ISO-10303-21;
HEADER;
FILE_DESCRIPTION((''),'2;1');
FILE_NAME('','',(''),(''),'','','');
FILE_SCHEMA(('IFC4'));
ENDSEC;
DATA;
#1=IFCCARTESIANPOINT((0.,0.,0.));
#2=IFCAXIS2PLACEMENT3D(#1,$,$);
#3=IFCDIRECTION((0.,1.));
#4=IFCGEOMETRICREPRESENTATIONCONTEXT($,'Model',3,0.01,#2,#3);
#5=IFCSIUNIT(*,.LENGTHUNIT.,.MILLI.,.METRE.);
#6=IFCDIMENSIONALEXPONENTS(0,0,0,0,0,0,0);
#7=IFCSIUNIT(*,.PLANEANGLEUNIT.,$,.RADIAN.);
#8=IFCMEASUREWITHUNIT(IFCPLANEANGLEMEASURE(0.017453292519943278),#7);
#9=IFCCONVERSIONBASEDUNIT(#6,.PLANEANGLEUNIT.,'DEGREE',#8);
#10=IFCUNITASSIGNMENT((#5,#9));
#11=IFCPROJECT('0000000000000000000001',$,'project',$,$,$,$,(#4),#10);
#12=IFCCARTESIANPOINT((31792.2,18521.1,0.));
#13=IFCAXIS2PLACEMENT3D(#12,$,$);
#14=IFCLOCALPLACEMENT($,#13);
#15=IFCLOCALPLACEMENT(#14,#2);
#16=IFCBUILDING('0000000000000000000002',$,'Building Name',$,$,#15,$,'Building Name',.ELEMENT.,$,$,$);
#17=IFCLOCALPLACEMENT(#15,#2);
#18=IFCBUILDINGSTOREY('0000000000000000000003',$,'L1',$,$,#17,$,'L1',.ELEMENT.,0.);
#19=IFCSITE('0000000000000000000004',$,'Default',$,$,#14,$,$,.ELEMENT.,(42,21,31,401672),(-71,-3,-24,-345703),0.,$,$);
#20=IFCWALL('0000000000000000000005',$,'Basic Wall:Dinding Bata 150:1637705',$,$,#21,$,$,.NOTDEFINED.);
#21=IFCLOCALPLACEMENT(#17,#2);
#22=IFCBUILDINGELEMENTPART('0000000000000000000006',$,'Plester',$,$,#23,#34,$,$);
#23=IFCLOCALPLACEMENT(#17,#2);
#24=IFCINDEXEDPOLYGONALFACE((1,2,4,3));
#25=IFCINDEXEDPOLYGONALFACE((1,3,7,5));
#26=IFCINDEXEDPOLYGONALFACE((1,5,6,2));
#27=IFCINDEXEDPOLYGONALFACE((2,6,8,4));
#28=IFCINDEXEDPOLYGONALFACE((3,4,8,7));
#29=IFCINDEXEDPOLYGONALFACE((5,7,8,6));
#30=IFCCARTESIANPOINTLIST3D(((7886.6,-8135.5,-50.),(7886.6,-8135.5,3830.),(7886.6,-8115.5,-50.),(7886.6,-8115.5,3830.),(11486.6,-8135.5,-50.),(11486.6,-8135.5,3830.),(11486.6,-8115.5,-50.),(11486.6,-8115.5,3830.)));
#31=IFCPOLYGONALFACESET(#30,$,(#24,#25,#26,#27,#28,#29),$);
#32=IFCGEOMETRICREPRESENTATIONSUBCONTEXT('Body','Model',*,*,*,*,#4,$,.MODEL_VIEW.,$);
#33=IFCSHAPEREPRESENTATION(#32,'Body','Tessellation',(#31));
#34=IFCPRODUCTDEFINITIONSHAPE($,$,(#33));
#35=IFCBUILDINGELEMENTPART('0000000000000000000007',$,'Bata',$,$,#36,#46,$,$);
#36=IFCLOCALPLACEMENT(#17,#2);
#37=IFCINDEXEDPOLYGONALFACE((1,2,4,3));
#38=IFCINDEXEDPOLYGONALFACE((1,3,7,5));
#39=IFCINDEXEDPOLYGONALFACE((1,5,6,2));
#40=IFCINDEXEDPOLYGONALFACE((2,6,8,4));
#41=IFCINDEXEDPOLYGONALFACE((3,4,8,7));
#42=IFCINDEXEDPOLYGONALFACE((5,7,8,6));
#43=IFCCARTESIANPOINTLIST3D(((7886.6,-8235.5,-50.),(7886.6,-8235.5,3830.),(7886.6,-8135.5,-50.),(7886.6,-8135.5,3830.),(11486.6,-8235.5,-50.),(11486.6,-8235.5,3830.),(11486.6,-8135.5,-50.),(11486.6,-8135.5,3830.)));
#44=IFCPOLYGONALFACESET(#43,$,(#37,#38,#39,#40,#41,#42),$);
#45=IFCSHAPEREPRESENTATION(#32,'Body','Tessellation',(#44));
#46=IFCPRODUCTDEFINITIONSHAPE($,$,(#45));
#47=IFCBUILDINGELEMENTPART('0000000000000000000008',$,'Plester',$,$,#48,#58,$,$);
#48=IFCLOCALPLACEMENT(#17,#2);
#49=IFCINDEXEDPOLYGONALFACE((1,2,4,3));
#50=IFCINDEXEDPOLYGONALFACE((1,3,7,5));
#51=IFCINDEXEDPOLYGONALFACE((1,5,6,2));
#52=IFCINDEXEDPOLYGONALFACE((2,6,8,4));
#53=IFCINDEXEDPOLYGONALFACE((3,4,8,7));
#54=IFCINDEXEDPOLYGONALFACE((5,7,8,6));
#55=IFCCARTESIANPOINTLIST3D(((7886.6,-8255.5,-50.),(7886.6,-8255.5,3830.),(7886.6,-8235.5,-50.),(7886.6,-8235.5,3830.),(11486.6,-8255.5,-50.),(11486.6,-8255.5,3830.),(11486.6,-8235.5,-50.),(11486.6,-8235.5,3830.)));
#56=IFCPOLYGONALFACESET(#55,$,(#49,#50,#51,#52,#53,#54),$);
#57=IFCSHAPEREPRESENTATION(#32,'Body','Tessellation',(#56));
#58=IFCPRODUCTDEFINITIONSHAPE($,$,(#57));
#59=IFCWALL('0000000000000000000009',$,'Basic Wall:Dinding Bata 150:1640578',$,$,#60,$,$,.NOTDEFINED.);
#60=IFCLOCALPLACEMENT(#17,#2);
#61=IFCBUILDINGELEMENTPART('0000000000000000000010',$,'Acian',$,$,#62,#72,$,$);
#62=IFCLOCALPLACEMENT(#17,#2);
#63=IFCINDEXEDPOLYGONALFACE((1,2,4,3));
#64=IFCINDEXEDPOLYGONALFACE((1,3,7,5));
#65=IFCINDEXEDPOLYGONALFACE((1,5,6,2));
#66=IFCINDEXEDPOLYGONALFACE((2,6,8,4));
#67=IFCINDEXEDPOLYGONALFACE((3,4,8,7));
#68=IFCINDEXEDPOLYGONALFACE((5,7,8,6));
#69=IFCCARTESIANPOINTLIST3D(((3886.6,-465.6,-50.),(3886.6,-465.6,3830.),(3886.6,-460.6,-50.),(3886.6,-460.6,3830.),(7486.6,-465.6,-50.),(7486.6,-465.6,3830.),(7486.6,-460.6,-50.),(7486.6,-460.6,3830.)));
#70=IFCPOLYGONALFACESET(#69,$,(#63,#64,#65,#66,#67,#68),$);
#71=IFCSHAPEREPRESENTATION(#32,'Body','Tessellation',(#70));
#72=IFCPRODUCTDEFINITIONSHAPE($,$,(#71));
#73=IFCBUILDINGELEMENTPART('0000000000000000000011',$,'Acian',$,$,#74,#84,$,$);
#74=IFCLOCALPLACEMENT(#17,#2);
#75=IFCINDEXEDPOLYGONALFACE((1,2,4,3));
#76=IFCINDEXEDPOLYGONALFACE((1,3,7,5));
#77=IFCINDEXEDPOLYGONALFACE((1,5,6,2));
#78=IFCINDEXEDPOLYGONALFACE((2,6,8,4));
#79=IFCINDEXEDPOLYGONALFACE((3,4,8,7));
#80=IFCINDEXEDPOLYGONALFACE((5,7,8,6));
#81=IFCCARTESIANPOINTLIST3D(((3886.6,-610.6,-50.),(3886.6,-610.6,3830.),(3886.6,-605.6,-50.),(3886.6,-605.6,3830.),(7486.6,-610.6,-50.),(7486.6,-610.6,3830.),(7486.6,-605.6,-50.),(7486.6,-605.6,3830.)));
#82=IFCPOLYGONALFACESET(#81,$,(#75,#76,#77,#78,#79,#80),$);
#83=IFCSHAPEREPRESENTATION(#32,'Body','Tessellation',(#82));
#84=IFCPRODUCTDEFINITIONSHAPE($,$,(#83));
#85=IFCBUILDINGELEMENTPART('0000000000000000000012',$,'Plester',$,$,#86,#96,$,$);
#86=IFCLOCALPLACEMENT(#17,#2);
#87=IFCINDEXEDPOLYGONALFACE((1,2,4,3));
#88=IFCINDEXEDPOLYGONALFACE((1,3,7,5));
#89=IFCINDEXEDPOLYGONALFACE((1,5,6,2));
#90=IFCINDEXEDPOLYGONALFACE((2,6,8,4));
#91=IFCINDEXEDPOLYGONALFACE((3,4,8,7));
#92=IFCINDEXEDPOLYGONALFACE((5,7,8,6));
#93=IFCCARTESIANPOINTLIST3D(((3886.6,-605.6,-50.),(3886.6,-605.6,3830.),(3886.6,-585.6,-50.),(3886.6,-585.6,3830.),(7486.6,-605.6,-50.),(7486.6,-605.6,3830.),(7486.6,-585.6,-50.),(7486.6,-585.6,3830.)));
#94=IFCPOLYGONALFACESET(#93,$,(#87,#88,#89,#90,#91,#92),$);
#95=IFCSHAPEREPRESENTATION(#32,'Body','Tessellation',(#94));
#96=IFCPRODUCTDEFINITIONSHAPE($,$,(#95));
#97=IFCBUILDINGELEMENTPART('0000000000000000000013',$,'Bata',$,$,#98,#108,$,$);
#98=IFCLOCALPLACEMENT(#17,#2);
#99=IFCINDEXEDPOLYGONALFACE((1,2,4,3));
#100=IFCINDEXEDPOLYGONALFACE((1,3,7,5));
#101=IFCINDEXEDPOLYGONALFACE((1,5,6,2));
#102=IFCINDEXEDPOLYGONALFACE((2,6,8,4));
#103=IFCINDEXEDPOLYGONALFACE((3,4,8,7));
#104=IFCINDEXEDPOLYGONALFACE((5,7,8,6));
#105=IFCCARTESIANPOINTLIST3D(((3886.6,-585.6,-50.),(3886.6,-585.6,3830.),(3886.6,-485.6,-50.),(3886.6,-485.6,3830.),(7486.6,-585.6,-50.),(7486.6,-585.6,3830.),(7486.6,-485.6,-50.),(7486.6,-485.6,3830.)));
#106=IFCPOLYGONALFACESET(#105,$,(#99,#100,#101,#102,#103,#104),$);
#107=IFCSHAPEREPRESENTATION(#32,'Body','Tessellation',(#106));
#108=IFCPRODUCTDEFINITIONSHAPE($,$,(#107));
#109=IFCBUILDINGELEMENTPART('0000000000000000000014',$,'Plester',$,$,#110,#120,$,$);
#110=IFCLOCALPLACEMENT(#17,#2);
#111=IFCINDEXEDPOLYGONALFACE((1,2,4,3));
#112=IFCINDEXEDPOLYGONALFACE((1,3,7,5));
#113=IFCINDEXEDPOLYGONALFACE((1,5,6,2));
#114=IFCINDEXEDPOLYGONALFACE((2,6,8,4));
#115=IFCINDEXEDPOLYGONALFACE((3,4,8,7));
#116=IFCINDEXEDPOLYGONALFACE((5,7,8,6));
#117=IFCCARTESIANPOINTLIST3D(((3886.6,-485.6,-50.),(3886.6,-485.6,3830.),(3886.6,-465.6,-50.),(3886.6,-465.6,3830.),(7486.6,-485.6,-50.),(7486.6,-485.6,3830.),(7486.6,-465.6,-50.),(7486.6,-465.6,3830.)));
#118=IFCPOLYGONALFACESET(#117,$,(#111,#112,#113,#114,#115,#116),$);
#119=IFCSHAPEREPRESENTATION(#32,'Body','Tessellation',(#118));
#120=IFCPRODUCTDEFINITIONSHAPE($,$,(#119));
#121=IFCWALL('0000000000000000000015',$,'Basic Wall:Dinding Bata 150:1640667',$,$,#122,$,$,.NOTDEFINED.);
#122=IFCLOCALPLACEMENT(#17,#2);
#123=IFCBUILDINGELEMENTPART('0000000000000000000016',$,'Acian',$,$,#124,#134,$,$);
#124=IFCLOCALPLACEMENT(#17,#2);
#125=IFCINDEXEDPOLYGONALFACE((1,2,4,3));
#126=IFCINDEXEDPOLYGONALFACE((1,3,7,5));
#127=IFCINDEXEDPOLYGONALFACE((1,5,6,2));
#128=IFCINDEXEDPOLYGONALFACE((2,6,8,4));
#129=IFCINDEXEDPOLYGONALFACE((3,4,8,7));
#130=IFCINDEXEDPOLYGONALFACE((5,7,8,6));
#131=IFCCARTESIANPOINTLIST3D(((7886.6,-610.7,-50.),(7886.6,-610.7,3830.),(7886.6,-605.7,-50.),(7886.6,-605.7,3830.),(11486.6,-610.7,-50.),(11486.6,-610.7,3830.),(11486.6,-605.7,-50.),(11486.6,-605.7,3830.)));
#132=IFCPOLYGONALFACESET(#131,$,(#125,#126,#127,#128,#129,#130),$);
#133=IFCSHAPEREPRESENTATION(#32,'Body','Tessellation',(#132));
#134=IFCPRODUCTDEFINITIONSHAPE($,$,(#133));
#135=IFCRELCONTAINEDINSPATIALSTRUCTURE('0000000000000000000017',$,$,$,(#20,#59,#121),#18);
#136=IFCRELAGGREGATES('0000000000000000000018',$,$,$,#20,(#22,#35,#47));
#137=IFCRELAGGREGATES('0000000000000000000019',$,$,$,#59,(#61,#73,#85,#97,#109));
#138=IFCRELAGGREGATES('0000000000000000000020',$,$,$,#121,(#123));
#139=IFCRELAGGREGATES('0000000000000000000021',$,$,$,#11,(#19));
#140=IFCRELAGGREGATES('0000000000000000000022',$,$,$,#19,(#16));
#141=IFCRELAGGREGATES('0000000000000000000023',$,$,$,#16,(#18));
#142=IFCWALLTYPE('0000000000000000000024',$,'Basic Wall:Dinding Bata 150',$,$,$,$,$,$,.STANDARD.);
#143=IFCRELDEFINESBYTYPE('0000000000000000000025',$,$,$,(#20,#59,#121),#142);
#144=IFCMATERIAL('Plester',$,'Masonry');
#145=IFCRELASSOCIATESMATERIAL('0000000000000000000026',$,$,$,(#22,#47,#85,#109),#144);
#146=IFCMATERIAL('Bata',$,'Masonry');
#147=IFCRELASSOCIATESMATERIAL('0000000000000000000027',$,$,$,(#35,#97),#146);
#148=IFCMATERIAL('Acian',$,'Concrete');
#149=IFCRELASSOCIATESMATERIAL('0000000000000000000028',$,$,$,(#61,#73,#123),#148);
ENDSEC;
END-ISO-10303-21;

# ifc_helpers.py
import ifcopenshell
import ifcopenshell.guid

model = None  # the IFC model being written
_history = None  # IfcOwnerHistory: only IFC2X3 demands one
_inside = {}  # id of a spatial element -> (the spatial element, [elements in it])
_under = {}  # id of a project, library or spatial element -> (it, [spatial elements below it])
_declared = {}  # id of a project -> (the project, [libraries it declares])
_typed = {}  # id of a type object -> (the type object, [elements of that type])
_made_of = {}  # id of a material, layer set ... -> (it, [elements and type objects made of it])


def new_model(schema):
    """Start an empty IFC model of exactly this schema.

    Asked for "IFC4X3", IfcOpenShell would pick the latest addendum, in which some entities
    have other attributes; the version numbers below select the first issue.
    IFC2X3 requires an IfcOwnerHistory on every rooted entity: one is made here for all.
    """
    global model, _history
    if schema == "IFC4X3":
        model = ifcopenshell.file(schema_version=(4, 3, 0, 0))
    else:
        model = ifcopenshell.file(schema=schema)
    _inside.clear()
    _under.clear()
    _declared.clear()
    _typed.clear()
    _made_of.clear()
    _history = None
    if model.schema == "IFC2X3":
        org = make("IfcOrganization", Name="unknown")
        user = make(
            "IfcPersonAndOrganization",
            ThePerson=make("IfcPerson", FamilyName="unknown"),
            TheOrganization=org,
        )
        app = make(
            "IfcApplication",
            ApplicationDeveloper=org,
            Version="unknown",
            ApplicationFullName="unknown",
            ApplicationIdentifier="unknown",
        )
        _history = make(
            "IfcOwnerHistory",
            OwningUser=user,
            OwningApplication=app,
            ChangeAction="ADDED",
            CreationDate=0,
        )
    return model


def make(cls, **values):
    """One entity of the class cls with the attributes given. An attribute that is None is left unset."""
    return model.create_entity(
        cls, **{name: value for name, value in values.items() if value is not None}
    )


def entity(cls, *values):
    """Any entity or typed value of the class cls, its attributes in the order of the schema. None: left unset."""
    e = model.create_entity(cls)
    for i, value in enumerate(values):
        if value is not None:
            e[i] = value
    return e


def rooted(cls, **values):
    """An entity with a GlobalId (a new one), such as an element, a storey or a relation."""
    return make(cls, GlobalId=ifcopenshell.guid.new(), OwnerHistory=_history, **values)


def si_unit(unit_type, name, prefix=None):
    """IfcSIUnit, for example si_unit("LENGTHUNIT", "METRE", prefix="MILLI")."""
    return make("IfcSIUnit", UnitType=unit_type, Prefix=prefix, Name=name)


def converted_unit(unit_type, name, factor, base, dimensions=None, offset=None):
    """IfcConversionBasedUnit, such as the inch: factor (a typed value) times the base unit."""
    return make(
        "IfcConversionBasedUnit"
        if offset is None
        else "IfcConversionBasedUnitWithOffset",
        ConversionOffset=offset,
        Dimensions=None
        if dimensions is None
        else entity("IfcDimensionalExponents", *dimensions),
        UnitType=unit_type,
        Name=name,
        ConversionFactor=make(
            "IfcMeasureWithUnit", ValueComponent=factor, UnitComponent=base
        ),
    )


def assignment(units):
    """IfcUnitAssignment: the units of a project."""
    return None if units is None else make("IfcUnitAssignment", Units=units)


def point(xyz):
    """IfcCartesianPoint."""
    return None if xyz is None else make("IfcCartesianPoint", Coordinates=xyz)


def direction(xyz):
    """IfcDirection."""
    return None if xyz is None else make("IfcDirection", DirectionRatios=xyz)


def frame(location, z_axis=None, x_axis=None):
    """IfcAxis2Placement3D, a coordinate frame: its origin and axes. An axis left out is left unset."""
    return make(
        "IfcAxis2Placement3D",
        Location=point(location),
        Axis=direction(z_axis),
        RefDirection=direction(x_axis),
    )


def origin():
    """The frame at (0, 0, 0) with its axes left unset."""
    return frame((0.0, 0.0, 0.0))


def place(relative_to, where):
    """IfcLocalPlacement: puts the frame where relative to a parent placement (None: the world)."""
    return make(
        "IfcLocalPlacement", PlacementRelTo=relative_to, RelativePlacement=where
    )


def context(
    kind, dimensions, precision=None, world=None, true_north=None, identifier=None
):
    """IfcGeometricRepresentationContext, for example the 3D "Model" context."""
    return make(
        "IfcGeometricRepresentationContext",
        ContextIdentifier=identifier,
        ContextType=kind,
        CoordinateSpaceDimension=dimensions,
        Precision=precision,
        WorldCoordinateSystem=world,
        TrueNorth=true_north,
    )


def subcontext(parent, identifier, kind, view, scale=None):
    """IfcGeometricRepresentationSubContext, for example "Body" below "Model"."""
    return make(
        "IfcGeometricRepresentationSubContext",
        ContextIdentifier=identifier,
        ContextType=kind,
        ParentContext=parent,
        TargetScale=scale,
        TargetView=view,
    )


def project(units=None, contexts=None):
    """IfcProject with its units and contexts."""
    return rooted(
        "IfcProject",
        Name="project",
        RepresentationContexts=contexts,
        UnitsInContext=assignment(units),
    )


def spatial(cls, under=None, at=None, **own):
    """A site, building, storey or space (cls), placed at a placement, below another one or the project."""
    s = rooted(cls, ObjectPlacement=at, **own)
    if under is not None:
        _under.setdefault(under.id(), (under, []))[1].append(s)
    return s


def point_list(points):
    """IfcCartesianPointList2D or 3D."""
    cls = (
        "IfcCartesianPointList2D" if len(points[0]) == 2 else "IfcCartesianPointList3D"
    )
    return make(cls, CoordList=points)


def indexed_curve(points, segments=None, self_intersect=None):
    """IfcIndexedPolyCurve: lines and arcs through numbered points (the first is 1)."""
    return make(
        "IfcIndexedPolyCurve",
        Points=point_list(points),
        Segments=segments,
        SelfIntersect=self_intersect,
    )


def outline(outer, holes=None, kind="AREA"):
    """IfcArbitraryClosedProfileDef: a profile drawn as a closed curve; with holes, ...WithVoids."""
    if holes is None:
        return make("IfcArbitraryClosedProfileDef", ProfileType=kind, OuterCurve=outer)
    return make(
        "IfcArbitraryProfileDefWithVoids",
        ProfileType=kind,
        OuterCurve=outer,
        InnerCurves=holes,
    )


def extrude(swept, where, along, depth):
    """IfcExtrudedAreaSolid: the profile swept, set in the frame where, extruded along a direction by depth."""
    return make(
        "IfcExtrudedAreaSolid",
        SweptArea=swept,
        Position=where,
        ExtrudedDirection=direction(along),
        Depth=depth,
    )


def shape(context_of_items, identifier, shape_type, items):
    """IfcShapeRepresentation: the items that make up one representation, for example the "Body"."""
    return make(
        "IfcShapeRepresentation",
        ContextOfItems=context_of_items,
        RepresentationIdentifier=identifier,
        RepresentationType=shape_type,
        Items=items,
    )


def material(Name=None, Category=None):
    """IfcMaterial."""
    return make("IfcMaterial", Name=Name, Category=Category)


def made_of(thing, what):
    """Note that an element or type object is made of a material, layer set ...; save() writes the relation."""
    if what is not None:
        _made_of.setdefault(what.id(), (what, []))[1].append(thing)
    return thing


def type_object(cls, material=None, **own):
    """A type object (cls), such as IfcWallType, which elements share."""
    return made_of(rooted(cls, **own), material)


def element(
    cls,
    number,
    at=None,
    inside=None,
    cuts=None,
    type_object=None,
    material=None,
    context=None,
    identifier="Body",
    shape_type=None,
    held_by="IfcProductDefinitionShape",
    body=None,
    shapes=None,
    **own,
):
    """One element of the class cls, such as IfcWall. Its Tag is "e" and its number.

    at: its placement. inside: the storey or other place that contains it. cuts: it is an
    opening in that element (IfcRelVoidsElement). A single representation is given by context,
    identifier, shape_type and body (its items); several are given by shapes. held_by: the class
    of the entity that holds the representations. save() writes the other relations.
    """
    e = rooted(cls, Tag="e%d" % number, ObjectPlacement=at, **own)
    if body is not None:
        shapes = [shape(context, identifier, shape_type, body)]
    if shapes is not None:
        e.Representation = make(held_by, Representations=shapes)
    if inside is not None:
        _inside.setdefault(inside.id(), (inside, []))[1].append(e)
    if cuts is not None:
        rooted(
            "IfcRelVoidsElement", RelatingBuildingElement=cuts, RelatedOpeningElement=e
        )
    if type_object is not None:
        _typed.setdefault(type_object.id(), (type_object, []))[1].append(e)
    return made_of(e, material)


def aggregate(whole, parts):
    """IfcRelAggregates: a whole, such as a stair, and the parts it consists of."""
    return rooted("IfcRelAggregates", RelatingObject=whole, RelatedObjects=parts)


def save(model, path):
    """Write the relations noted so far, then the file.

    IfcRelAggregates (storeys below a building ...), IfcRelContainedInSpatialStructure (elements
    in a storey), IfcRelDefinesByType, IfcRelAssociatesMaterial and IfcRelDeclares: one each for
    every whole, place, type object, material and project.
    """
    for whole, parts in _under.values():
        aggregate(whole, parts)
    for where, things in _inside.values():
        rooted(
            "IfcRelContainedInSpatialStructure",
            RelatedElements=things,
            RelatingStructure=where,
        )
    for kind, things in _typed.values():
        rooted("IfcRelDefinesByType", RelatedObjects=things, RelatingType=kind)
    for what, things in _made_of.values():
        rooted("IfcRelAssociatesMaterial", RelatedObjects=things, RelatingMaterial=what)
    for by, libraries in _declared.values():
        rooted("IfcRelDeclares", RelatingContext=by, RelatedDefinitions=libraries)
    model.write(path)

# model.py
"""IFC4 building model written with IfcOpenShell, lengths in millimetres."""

from ifc_helpers import new_model, entity, si_unit, converted_unit, direction, frame, origin, place, context, subcontext, project, spatial, indexed_curve, outline, extrude, material, type_object, element, aggregate, save


model = new_model("IFC4")

# Units and contexts
model_context = context("Model", 3, precision=0.01, world=origin(), true_north=direction((0.0, 1.0)))
body_context = subcontext(model_context, "Body", "Model", "MODEL_VIEW")
ifc_project = project(units=[si_unit("LENGTHUNIT", "METRE", prefix="MILLI"), converted_unit("PLANEANGLEUNIT", "DEGREE", entity("IfcPlaneAngleMeasure", 0.017453292519943278), si_unit("PLANEANGLEUNIT", "RADIAN"), dimensions=[0, 0, 0, 0, 0, 0, 0])], contexts=[model_context])

# Site, building, storey
site_placement = place(None, frame((31792.2, 18521.1, 0.0)))
site = spatial("IfcSite", under=ifc_project, at=site_placement, Name="Default", CompositionType="ELEMENT", RefLatitude=(42, 21, 31, 401672), RefLongitude=(-71, -3, -24, -345703), RefElevation=0.0)
building_placement = place(site_placement, origin())
building = spatial("IfcBuilding", under=site, at=building_placement, Name="Building Name", LongName="Building Name", CompositionType="ELEMENT")
storey_placement = place(building_placement, origin())
storey = spatial("IfcBuildingStorey", under=building, at=storey_placement, Name="L1", LongName="L1", CompositionType="ELEMENT", Elevation=0.0)

# Walls, building element parts
wall_type = type_object("IfcWallType", Name="Basic Wall:Dinding Bata 150", PredefinedType="STANDARD")
ifc_material_1 = material(Name="Bata", Category="Masonry")
ifc_material_2 = material(Name="Plester", Category="Masonry")
ifc_material_3 = material(Name="Acian", Category="Concrete")
wall_1_placement = place(storey_placement, frame((7886.6, -8185.5, -50.0)))
wall_1 = element("IfcWall", 1, at=wall_1_placement, inside=storey, type_object=wall_type, Name="Basic Wall:Dinding Bata 150:1637705", PredefinedType="NOTDEFINED")
building_element_part_1_placement = place(wall_1_placement, origin())
building_element_part_1 = element("IfcBuildingElementPart", 2, at=building_element_part_1_placement, material=ifc_material_2, Name="Plester", context=body_context, shape_type="SweptSolid", body=[
    extrude(outline(indexed_curve([(-10.0, -1800.0), (10.0, -1800.0), (10.0, 1800.0), (-10.0, 1800.0), (-10.0, -1800.0)], self_intersect=False)), frame((1800.0, 60.0, 0.0), z_axis=(0.0, 0.0, 1.0), x_axis=(0.0, -1.0, 0.0)), (0.0, 0.0, 1.0), 3880.0),
])
building_element_part_2_placement = place(wall_1_placement, origin())
building_element_part_2 = element("IfcBuildingElementPart", 3, at=building_element_part_2_placement, material=ifc_material_1, Name="Bata", context=body_context, shape_type="SweptSolid", body=[
    extrude(outline(indexed_curve([(-50.0, -1800.0), (50.0, -1800.0), (50.0, 1800.0), (-50.0, 1800.0), (-50.0, -1800.0)], self_intersect=False)), frame((1800.0, 0.0, 0.0), z_axis=(0.0, 0.0, 1.0), x_axis=(0.0, -1.0, 0.0)), (0.0, 0.0, 1.0), 3880.0),
])
building_element_part_3_placement = place(wall_1_placement, origin())
building_element_part_3 = element("IfcBuildingElementPart", 4, at=building_element_part_3_placement, material=ifc_material_2, Name="Plester", context=body_context, shape_type="SweptSolid", body=[
    extrude(outline(indexed_curve([(-10.0, -1800.0), (10.0, -1800.0), (10.0, 1800.0), (-10.0, 1800.0), (-10.0, -1800.0)], self_intersect=False)), frame((1800.0, -60.0, 0.0), z_axis=(0.0, 0.0, 1.0), x_axis=(0.0, -1.0, 0.0)), (0.0, 0.0, 1.0), 3880.0),
])
aggregate(wall_1, [building_element_part_1, building_element_part_2, building_element_part_3])
wall_2_placement = place(storey_placement, frame((7486.6, -535.6, -50.0), z_axis=(0.0, 0.0, 1.0), x_axis=(-1.0, 0.0, 0.0)))
wall_2 = element("IfcWall", 5, at=wall_2_placement, inside=storey, type_object=wall_type, Name="Basic Wall:Dinding Bata 150:1640578", PredefinedType="NOTDEFINED")
building_element_part_4_placement = place(wall_2_placement, origin())
building_element_part_4 = element("IfcBuildingElementPart", 6, at=building_element_part_4_placement, material=ifc_material_3, Name="Acian", context=body_context, shape_type="SweptSolid", body=[
    extrude(outline(indexed_curve([(-2.5, -1800.0), (2.5, -1800.0), (2.5, 1800.0), (-2.5, 1800.0), (-2.5, -1800.0)], self_intersect=False)), frame((1800.0, -72.5, 0.0), z_axis=(0.0, 0.0, 1.0), x_axis=(0.0, 1.0, 0.0)), (0.0, 0.0, 1.0), 3880.0),
])
building_element_part_5_placement = place(wall_2_placement, origin())
building_element_part_5 = element("IfcBuildingElementPart", 7, at=building_element_part_5_placement, material=ifc_material_3, Name="Acian", context=body_context, shape_type="SweptSolid", body=[
    extrude(outline(indexed_curve([(-2.5, -1800.0), (2.5, -1800.0), (2.5, 1800.0), (-2.5, 1800.0), (-2.5, -1800.0)], self_intersect=False)), frame((1800.0, 72.5, 0.0), z_axis=(0.0, 0.0, 1.0), x_axis=(0.0, 1.0, 0.0)), (0.0, 0.0, 1.0), 3880.0),
])
building_element_part_6_placement = place(wall_2_placement, origin())
building_element_part_6 = element("IfcBuildingElementPart", 8, at=building_element_part_6_placement, material=ifc_material_2, Name="Plester", context=body_context, shape_type="SweptSolid", body=[
    extrude(outline(indexed_curve([(-10.0, -1800.0), (10.0, -1800.0), (10.0, 1800.0), (-10.0, 1800.0), (-10.0, -1800.0)], self_intersect=False)), frame((1800.0, 60.0, 0.0), z_axis=(0.0, 0.0, 1.0), x_axis=(0.0, 1.0, 0.0)), (0.0, 0.0, 1.0), 3880.0),
])
building_element_part_7_placement = place(wall_2_placement, origin())
building_element_part_7 = element("IfcBuildingElementPart", 9, at=building_element_part_7_placement, material=ifc_material_1, Name="Bata", context=body_context, shape_type="SweptSolid", body=[
    extrude(outline(indexed_curve([(-50.0, -1800.0), (50.0, -1800.0), (50.0, 1800.0), (-50.0, 1800.0), (-50.0, -1800.0)], self_intersect=False)), frame((1800.0, 0.0, 0.0), z_axis=(0.0, 0.0, 1.0), x_axis=(0.0, 1.0, 0.0)), (0.0, 0.0, 1.0), 3880.0),
])
building_element_part_8_placement = place(wall_2_placement, origin())
building_element_part_8 = element("IfcBuildingElementPart", 10, at=building_element_part_8_placement, material=ifc_material_2, Name="Plester", context=body_context, shape_type="SweptSolid", body=[
    extrude(outline(indexed_curve([(-10.0, -1800.0), (10.0, -1800.0), (10.0, 1800.0), (-10.0, 1800.0), (-10.0, -1800.0)], self_intersect=False)), frame((1800.0, -60.0, 0.0), z_axis=(0.0, 0.0, 1.0), x_axis=(0.0, 1.0, 0.0)), (0.0, 0.0, 1.0), 3880.0),
])
aggregate(wall_2, [building_element_part_4, building_element_part_5, building_element_part_6, building_element_part_7, building_element_part_8])

# Wall, building element part
wall_3_placement = place(storey_placement, frame((7886.6, -535.7, -50.0)))
wall_3 = element("IfcWall", 11, at=wall_3_placement, inside=storey, type_object=wall_type, Name="Basic Wall:Dinding Bata 150:1640667", PredefinedType="NOTDEFINED")
building_element_part_9_placement = place(wall_3_placement, origin())
building_element_part_9 = element("IfcBuildingElementPart", 12, at=building_element_part_9_placement, material=ifc_material_3, Name="Acian", context=body_context, shape_type="SweptSolid", body=[
    extrude(outline(indexed_curve([(-2.5, -1800.0), (2.5, -1800.0), (2.5, 1800.0), (-2.5, 1800.0), (-2.5, -1800.0)], self_intersect=False)), frame((1800.0, -72.5, 0.0), z_axis=(0.0, 0.0, 1.0), x_axis=(0.0, -1.0, 0.0)), (0.0, 0.0, 1.0), 3880.0),
])
aggregate(wall_3, [building_element_part_9])

save(model, "model.ifc")
